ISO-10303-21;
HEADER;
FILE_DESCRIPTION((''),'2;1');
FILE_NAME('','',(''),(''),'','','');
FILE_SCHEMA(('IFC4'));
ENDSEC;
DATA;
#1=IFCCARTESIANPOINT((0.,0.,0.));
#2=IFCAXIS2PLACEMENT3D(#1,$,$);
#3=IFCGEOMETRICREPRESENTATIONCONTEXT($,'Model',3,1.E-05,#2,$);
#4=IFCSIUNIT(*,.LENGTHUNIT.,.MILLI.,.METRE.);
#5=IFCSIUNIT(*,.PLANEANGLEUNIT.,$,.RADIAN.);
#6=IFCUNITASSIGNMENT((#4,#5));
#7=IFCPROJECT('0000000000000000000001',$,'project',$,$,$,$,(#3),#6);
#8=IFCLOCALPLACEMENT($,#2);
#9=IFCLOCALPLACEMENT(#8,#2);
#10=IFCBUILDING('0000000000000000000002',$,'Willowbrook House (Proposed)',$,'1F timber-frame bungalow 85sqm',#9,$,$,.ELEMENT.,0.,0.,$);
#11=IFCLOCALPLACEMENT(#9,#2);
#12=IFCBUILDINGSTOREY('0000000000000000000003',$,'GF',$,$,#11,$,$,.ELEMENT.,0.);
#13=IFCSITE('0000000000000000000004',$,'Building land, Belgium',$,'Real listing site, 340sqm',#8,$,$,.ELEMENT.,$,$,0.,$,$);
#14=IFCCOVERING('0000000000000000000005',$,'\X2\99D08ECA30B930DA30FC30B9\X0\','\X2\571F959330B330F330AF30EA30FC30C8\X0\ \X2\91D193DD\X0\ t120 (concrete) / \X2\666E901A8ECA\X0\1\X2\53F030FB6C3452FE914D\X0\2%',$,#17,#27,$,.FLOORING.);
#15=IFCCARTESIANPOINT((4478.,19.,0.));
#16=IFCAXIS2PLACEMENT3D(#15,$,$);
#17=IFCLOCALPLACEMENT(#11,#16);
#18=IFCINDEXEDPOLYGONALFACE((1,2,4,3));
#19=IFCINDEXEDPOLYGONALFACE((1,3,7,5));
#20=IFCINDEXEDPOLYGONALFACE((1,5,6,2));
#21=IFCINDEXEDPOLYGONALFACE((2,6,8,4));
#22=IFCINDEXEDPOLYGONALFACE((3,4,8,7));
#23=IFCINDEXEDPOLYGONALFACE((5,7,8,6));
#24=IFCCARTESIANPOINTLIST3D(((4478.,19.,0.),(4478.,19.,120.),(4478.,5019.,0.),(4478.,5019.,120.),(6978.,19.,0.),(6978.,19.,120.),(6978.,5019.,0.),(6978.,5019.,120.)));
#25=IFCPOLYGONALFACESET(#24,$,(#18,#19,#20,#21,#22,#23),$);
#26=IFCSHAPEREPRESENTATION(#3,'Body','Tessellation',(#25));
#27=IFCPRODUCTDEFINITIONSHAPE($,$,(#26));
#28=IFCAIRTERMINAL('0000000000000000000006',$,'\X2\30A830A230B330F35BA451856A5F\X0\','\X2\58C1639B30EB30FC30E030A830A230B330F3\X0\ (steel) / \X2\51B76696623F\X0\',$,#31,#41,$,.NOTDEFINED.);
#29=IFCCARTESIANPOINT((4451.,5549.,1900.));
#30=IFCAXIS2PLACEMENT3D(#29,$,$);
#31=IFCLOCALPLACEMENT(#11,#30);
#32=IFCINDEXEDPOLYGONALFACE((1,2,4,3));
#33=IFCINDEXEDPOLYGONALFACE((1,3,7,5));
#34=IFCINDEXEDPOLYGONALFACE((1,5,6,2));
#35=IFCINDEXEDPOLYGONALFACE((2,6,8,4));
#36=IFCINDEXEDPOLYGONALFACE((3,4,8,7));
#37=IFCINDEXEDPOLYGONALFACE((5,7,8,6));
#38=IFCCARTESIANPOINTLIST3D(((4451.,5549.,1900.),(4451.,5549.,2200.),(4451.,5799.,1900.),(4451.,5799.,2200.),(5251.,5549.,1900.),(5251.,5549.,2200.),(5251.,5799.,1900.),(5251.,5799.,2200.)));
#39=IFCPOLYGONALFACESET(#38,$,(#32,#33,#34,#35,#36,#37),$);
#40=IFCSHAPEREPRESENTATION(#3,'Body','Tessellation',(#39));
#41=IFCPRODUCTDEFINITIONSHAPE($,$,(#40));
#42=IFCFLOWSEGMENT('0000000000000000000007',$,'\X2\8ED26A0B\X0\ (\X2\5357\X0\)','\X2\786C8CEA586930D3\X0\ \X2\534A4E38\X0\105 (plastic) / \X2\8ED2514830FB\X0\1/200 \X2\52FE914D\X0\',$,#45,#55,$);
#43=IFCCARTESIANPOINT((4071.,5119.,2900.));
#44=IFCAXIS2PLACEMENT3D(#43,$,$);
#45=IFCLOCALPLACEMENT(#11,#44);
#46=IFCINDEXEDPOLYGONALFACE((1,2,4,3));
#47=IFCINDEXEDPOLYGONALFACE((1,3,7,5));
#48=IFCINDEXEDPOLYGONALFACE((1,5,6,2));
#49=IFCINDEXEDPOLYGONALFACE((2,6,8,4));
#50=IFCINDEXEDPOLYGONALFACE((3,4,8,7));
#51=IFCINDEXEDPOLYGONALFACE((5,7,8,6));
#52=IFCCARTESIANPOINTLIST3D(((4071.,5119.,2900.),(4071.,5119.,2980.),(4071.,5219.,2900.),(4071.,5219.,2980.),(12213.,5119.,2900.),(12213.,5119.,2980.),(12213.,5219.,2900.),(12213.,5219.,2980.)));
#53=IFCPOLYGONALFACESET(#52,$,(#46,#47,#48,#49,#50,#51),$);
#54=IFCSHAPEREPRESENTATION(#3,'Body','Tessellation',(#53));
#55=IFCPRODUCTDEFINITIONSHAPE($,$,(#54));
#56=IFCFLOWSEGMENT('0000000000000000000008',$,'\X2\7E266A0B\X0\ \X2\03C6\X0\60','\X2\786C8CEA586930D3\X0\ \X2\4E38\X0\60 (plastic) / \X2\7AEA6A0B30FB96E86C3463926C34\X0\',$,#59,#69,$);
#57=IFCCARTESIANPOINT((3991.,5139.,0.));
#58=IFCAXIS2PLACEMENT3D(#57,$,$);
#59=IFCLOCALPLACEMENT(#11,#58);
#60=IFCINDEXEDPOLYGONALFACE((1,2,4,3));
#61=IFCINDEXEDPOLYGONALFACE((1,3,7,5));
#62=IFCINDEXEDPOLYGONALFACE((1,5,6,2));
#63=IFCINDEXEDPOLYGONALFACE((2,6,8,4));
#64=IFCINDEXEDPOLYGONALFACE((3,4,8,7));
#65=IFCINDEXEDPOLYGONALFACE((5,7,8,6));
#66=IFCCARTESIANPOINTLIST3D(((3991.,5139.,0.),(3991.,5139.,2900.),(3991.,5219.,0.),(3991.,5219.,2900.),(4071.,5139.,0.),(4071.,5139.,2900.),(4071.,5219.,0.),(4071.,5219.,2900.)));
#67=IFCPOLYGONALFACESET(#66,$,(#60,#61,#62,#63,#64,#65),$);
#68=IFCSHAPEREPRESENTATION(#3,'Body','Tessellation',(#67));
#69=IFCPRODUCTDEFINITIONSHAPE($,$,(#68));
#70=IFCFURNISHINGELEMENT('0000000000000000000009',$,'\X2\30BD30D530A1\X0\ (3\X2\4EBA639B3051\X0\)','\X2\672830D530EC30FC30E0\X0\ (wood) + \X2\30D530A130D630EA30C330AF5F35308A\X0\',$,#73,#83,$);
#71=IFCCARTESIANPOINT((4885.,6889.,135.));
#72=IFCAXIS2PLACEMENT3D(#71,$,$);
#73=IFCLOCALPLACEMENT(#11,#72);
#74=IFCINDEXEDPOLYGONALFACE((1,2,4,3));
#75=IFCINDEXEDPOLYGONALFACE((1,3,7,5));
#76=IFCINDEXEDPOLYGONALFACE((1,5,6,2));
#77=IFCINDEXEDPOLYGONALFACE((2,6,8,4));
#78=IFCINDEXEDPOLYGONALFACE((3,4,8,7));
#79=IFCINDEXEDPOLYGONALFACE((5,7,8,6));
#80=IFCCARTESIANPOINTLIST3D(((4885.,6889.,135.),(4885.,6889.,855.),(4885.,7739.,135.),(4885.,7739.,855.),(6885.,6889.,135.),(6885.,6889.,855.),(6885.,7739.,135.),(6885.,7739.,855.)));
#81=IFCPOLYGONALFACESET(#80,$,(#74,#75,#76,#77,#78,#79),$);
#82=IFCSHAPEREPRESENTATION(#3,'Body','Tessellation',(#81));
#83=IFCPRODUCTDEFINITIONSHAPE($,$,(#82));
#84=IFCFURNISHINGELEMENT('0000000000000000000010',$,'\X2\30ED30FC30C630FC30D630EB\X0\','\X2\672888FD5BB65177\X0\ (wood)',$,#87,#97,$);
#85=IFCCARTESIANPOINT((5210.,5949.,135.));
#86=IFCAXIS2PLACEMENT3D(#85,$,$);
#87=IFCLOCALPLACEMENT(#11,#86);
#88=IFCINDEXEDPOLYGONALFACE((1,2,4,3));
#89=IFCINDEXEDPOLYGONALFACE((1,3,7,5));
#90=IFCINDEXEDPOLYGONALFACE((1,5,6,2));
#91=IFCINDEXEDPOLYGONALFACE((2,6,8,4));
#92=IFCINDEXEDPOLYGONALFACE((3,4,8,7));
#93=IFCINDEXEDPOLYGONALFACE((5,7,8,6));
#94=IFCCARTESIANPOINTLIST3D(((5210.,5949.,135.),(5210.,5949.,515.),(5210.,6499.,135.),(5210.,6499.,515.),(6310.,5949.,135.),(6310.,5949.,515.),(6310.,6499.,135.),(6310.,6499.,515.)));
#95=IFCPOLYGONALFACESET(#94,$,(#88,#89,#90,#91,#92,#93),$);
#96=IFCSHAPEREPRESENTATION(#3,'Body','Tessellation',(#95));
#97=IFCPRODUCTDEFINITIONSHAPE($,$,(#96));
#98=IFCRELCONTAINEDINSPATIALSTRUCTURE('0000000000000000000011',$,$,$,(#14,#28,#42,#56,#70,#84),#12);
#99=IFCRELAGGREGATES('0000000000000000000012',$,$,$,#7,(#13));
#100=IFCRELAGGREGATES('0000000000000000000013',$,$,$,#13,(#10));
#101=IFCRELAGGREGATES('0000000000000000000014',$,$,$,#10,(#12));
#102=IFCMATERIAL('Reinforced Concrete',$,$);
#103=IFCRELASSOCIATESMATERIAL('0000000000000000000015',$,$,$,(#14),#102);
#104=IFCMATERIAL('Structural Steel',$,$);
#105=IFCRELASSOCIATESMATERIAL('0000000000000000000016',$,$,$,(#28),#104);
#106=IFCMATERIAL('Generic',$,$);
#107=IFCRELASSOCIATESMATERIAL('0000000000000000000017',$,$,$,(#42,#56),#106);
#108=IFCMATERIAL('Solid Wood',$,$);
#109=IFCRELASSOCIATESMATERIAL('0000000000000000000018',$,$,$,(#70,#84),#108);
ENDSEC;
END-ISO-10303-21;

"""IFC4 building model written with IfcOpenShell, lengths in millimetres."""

from ifc_helpers import new_model, si_unit, frame, frame_2d, origin, place, context, project, spatial, rectangle, extrude, material, element, save


model = new_model("IFC4")

# Units and contexts
model_context = context("Model", 3, precision=1e-05, world=origin())
ifc_project = project(units=[si_unit("LENGTHUNIT", "METRE", prefix="MILLI"), si_unit("PLANEANGLEUNIT", "RADIAN")], contexts=[model_context])

# Site, building, storey
site_placement = place(None, origin())
site = spatial("IfcSite", under=ifc_project, at=site_placement, Name="Building land, Belgium", ObjectType="Real listing site, 340sqm", CompositionType="ELEMENT", RefElevation=0.0)
building_placement = place(site_placement, origin())
building = spatial("IfcBuilding", under=site, at=building_placement, Name="Willowbrook House (Proposed)", ObjectType="1F timber-frame bungalow 85sqm", CompositionType="ELEMENT", ElevationOfRefHeight=0.0, ElevationOfTerrain=0.0)
storey_placement = place(building_placement, origin())
storey = spatial("IfcBuildingStorey", under=building, at=storey_placement, Name="GF", CompositionType="ELEMENT", Elevation=0.0)

# Shared definitions
ifc_material_1 = material(Name="Solid Wood")

# Shared definitions
ifc_material_2 = material(Name="Reinforced Concrete")

# Shared definitions
ifc_material_3 = material(Name="Structural Steel")

# Covering
ifc_material_4 = material(Name="Generic")
covering_1_placement = place(storey_placement, frame((4478.0, 19.0, 0.0)))
element("IfcCovering", 1, at=covering_1_placement, inside=storey, material=ifc_material_2, Name="駐車スペース", Description="土間コンクリート 金鏝 t120 (concrete) / 普通車1台・水勾配2%", PredefinedType="FLOORING", context=model_context, shape_type="SweptSolid", body=[
    extrude(rectangle(XDim=2500.0, YDim=5000.0, at=frame_2d((1250.0, 2500.0))), frame((4478.0, 19.0, 0.0)), (0.0, 0.0, 1.0), 120.0),
])

# Air terminal
air_terminal_placement = place(storey_placement, frame((4451.0, 5549.0, 1900.0)))
element("IfcAirTerminal", 2, at=air_terminal_placement, inside=storey, material=ifc_material_3, Name="エアコン室内機", Description="壁掛ルームエアコン (steel) / 冷暖房", PredefinedType="NOTDEFINED", context=model_context, shape_type="SweptSolid", body=[
    extrude(rectangle(XDim=800.0, YDim=250.0, at=frame_2d((400.0, 125.0))), frame((4451.0, 5549.0, 1900.0)), (0.0, 0.0, 1.0), 300.0),
])

# Flow segments
flow_segment_1_placement = place(storey_placement, frame((4071.0, 5119.0, 2900.0)))
element("IfcFlowSegment", 3, at=flow_segment_1_placement, inside=storey, material=ifc_material_4, Name="軒樋 (南)", Description="硬質塩ビ 半丸105 (plastic) / 軒先・1/200 勾配", context=model_context, shape_type="SweptSolid", body=[
    extrude(rectangle(XDim=8142.0, YDim=100.0, at=frame_2d((4071.0, 50.0))), frame((4071.0, 5119.0, 2900.0)), (0.0, 0.0, 1.0), 80.0),
])
flow_segment_2_placement = place(storey_placement, frame((3991.0, 5139.0, 0.0)))
element("IfcFlowSegment", 4, at=flow_segment_2_placement, inside=storey, material=ifc_material_4, Name="縦樋 φ60", Description="硬質塩ビ 丸60 (plastic) / 竪樋・雨水排水", context=model_context, shape_type="SweptSolid", body=[
    extrude(rectangle(XDim=80.0, YDim=80.0, at=frame_2d((40.0, 40.0))), frame((3991.0, 5139.0, 0.0)), (0.0, 0.0, 1.0), 2900.0),
])

# Furnishing elements
furnishing_1_placement = place(storey_placement, frame((4885.0, 6889.0, 135.0)))
element("IfcFurnishingElement", 5, at=furnishing_1_placement, inside=storey, material=ifc_material_1, Name="ソファ (3人掛け)", Description="木フレーム (wood) + ファブリック張り", context=model_context, shape_type="SweptSolid", body=[
    extrude(rectangle(XDim=2000.0, YDim=850.0, at=frame_2d((1000.0, 425.0))), frame((4885.0, 6889.0, 135.0)), (0.0, 0.0, 1.0), 720.0),
])
furnishing_2_placement = place(storey_placement, frame((5210.0, 5949.0, 135.0)))
element("IfcFurnishingElement", 6, at=furnishing_2_placement, inside=storey, material=ifc_material_1, Name="ローテーブル", Description="木製家具 (wood)", context=model_context, shape_type="SweptSolid", body=[
    extrude(rectangle(XDim=1100.0, YDim=550.0, at=frame_2d((550.0, 275.0))), frame((5210.0, 5949.0, 135.0)), (0.0, 0.0, 1.0), 380.0),
])

save(model, "model.ifc")
